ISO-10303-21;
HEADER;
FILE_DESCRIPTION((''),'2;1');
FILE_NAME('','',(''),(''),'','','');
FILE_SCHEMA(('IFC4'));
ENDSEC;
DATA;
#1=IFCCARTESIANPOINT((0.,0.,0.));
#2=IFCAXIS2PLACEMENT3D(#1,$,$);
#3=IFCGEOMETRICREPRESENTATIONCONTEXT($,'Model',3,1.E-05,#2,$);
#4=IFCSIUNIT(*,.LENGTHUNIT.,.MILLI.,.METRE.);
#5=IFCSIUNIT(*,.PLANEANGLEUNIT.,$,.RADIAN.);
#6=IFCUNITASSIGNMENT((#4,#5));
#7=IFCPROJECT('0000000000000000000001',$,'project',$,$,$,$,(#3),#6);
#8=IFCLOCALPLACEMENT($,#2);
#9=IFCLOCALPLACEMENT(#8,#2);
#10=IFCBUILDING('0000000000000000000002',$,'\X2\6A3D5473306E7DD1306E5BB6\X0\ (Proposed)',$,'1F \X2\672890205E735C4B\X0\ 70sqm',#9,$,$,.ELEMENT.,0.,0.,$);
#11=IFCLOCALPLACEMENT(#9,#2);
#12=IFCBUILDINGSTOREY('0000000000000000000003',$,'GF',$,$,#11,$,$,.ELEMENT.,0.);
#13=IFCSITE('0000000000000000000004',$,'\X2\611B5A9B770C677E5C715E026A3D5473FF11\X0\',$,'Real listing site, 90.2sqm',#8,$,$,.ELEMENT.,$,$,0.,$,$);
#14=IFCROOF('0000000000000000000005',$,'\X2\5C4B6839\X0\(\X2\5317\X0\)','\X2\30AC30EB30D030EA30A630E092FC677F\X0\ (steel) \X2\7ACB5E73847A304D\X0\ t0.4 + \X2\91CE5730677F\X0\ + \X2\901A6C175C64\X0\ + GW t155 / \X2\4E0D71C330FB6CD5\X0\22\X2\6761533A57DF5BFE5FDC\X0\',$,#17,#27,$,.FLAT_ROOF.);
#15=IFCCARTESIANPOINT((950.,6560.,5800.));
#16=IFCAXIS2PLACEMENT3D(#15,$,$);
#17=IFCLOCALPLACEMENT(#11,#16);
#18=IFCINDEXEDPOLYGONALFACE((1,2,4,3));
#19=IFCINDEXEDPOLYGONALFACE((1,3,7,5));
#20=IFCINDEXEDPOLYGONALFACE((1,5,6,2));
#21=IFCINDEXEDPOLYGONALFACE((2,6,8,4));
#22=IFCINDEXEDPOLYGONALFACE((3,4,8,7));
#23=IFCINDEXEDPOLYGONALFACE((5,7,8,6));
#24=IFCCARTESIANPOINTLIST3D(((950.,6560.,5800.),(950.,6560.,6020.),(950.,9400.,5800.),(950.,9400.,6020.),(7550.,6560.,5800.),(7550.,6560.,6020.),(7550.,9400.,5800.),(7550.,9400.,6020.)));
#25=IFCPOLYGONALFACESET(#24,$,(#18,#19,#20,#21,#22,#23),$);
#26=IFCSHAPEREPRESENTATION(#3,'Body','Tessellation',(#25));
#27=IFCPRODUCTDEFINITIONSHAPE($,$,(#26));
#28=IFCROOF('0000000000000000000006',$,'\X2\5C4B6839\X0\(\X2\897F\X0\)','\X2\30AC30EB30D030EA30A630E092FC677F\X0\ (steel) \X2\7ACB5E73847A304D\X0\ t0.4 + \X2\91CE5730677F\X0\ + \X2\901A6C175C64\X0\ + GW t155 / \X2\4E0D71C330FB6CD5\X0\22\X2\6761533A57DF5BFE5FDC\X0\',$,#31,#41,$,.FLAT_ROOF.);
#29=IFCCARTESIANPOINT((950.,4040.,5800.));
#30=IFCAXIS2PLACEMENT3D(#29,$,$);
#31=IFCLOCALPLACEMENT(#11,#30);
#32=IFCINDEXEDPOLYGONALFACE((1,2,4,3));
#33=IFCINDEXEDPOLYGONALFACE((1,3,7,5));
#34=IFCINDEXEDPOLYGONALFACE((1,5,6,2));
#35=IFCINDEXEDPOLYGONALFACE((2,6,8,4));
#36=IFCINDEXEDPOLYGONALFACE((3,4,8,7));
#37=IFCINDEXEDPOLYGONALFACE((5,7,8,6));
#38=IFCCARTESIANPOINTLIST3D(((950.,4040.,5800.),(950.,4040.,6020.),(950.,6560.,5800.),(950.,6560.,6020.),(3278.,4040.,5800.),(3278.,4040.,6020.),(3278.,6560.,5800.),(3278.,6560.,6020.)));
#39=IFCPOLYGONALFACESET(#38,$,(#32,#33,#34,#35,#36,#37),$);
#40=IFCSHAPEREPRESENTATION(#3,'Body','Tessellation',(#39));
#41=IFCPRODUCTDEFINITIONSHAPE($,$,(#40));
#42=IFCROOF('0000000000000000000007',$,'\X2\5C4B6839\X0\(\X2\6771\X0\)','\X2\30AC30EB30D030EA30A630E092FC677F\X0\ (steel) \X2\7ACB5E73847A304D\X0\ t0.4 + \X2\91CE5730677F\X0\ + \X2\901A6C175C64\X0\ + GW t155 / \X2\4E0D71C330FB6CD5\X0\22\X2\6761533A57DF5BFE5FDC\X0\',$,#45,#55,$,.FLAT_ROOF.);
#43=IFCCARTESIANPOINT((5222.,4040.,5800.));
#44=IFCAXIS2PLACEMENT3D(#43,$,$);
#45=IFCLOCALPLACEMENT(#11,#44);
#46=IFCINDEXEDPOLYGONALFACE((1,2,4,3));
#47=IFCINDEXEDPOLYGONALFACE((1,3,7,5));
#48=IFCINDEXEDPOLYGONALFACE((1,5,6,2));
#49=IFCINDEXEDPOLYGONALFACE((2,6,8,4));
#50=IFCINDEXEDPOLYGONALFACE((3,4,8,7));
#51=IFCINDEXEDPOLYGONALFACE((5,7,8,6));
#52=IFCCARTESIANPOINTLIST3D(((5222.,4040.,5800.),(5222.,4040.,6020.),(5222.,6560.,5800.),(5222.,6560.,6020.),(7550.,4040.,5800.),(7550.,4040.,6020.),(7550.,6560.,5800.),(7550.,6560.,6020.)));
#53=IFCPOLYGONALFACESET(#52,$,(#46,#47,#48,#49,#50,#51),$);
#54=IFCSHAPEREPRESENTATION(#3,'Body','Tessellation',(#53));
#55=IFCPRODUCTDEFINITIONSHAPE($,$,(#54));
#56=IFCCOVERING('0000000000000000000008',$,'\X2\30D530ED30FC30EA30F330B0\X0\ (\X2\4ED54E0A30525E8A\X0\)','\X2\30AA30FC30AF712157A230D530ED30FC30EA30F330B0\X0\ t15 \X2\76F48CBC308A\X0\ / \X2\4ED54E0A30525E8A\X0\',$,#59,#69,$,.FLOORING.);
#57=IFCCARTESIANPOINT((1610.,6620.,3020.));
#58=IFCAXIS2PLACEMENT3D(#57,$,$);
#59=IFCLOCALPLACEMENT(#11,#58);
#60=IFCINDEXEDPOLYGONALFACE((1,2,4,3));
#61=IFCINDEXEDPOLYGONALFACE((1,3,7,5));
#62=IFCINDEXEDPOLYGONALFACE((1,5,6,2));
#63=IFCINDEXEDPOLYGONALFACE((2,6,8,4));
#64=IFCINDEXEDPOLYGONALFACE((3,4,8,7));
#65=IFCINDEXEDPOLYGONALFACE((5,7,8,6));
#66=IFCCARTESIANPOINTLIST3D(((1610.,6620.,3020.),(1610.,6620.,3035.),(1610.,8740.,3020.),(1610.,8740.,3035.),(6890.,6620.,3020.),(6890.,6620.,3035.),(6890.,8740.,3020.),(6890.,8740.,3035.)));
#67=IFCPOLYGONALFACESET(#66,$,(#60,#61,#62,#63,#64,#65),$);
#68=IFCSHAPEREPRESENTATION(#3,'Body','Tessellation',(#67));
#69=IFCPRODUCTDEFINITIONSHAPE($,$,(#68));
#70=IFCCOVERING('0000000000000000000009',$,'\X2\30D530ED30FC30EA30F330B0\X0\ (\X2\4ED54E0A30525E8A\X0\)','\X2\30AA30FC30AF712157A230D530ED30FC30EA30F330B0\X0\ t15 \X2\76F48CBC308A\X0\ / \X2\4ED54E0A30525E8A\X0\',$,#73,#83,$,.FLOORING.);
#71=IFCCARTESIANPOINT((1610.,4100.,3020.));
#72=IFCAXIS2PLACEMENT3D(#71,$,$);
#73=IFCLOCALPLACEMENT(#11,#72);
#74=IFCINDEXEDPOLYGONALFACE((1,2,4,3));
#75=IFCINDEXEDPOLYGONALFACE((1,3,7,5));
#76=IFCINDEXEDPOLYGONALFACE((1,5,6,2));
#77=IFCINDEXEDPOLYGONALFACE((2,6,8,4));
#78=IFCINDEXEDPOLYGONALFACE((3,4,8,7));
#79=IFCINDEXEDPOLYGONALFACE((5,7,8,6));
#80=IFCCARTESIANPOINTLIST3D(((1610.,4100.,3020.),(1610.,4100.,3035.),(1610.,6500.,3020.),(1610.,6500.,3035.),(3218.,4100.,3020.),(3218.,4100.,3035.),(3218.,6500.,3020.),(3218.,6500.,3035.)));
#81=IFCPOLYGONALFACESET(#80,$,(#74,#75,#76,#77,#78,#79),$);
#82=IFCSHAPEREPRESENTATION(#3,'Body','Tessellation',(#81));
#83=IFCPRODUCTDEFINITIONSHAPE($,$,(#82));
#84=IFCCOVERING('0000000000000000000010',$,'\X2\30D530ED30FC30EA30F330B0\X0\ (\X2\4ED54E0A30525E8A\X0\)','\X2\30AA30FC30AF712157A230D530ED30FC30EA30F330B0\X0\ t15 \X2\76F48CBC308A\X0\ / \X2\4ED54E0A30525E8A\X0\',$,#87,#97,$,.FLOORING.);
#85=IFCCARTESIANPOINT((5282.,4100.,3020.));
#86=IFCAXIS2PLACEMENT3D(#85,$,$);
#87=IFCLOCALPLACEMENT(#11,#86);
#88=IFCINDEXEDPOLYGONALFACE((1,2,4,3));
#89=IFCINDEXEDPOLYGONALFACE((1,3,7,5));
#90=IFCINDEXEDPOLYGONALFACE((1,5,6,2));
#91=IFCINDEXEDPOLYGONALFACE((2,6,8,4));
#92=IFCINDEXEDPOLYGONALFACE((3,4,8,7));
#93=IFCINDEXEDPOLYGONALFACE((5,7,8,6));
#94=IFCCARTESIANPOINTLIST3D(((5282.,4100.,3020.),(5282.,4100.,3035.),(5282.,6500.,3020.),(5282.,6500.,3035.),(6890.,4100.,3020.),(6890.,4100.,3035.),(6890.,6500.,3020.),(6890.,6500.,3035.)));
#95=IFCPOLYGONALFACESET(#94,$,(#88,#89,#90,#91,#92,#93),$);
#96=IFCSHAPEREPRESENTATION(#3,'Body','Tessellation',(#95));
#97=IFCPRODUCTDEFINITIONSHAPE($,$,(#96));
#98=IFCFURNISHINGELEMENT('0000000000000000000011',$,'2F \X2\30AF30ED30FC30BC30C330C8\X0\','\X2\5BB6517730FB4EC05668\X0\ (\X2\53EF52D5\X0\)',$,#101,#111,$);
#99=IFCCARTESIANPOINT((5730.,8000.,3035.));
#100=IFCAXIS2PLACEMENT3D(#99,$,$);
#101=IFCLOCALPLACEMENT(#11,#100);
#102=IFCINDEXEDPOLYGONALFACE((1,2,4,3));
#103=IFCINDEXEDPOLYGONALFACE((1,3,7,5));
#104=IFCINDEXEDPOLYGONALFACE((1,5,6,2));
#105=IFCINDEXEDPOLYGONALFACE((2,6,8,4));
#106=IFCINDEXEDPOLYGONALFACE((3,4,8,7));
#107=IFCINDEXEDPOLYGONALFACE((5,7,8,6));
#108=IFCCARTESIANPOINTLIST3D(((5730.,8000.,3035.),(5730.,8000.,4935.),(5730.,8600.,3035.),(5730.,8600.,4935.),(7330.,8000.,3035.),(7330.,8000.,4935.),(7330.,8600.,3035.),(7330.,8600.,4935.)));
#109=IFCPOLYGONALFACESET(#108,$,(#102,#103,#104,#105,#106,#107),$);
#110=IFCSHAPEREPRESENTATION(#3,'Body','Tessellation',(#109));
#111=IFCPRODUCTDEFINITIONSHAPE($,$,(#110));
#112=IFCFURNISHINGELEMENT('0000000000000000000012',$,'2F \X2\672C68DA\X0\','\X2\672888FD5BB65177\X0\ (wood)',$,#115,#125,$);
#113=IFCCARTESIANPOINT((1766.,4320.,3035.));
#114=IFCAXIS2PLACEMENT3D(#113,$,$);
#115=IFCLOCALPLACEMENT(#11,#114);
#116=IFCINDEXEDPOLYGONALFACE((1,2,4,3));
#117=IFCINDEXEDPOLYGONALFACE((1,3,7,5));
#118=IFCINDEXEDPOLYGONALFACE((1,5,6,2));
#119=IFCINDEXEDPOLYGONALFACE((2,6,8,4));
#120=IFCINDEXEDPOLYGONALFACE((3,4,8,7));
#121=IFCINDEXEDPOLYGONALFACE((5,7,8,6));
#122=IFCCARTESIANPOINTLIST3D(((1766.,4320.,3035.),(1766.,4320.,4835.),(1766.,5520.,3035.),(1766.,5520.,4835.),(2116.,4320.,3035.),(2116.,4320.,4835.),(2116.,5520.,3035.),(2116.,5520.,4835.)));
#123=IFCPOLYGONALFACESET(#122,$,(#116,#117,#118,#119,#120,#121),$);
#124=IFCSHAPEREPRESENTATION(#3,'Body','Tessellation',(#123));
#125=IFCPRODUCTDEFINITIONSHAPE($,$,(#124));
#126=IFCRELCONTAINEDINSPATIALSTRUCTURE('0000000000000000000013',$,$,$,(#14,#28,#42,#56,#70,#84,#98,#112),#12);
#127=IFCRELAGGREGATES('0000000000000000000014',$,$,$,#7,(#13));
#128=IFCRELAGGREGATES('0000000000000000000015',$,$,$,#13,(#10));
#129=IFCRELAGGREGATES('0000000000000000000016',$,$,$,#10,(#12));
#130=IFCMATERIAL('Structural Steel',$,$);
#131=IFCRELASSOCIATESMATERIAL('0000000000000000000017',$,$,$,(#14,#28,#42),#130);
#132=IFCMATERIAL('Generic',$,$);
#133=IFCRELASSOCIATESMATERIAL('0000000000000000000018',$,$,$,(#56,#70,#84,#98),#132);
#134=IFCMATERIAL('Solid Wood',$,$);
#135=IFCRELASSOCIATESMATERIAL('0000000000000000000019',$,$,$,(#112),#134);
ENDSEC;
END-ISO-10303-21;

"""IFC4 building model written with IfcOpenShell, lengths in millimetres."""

from ifc_helpers import new_model, si_unit, frame, frame_2d, origin, place, context, project, spatial, rectangle, extrude, material, element, save


model = new_model("IFC4")

# Units and contexts
model_context = context("Model", 3, precision=1e-05, world=origin())
ifc_project = project(units=[si_unit("LENGTHUNIT", "METRE", prefix="MILLI"), si_unit("PLANEANGLEUNIT", "RADIAN")], contexts=[model_context])

# Site, building, storey
site_placement = place(None, origin())
site = spatial("IfcSite", under=ifc_project, at=site_placement, Name="愛媛県松山市樽味１", ObjectType="Real listing site, 90.2sqm", CompositionType="ELEMENT", RefElevation=0.0)
building_placement = place(site_placement, origin())
building = spatial("IfcBuilding", under=site, at=building_placement, Name="樽味の緑の家 (Proposed)", ObjectType="1F 木造平屋 70sqm", CompositionType="ELEMENT", ElevationOfRefHeight=0.0, ElevationOfTerrain=0.0)
storey_placement = place(building_placement, origin())
storey = spatial("IfcBuildingStorey", under=building, at=storey_placement, Name="GF", CompositionType="ELEMENT", Elevation=0.0)

# Shared definitions
ifc_material_1 = material(Name="Solid Wood")

# Shared definitions
ifc_material_2 = material(Name="Generic")

# Roofs
ifc_material_3 = material(Name="Structural Steel")
for number, where, name in (
    (1, (950.0, 6560.0, 5800.0), "屋根(北)"),
):
    element("IfcRoof", number, at=place(storey_placement, frame(where)), inside=storey, material=ifc_material_3, Name=name, Description="ガルバリウム鋼板 (steel) 立平葺き t0.4 + 野地板 + 通気層 + GW t155 / 不燃・法22条区域対応", PredefinedType="FLAT_ROOF", context=model_context, shape_type="SweptSolid", body=[
        extrude(rectangle(XDim=6600.0, YDim=2840.0, at=frame_2d((3300.0, 1420.0))), frame((950.0, 6560.0, 5800.0)), (0.0, 0.0, 1.0), 220.0),
    ])
roof_1_placement = place(storey_placement, frame((950.0, 4040.0, 5800.0)))
element("IfcRoof", 2, at=roof_1_placement, inside=storey, material=ifc_material_3, Name="屋根(西)", Description="ガルバリウム鋼板 (steel) 立平葺き t0.4 + 野地板 + 通気層 + GW t155 / 不燃・法22条区域対応", PredefinedType="FLAT_ROOF", context=model_context, shape_type="SweptSolid", body=[
    extrude(rectangle(XDim=2328.0, YDim=2520.0, at=frame_2d((1164.0, 1260.0))), frame((950.0, 4040.0, 5800.0)), (0.0, 0.0, 1.0), 220.0),
])
roof_2_placement = place(storey_placement, frame((5222.0, 4040.0, 5800.0)))
element("IfcRoof", 3, at=roof_2_placement, inside=storey, material=ifc_material_3, Name="屋根(東)", Description="ガルバリウム鋼板 (steel) 立平葺き t0.4 + 野地板 + 通気層 + GW t155 / 不燃・法22条区域対応", PredefinedType="FLAT_ROOF", context=model_context, shape_type="SweptSolid", body=[
    extrude(rectangle(XDim=2328.0, YDim=2520.0, at=frame_2d((1164.0, 1260.0))), frame((5222.0, 4040.0, 5800.0)), (0.0, 0.0, 1.0), 220.0),
])

# Coverings
covering_1_placement = place(storey_placement, frame((1610.0, 6620.0, 3020.0)))
element("IfcCovering", 4, at=covering_1_placement, inside=storey, material=ifc_material_2, Name="フローリング (仕上げ床)", Description="オーク無垢フローリング t15 直貼り / 仕上げ床", PredefinedType="FLOORING", context=model_context, shape_type="SweptSolid", body=[
    extrude(rectangle(XDim=5280.0, YDim=2120.0, at=frame_2d((2640.0, 1060.0))), frame((1610.0, 6620.0, 3020.0)), (0.0, 0.0, 1.0), 15.0),
])
covering_2_placement = place(storey_placement, frame((1610.0, 4100.0, 3020.0)))
element("IfcCovering", 5, at=covering_2_placement, inside=storey, material=ifc_material_2, Name="フローリング (仕上げ床)", Description="オーク無垢フローリング t15 直貼り / 仕上げ床", PredefinedType="FLOORING", context=model_context, shape_type="SweptSolid", body=[
    extrude(rectangle(XDim=1608.0, YDim=2400.0, at=frame_2d((804.0, 1200.0))), frame((1610.0, 4100.0, 3020.0)), (0.0, 0.0, 1.0), 15.0),
])
covering_3_placement = place(storey_placement, frame((5282.0, 4100.0, 3020.0)))
element("IfcCovering", 6, at=covering_3_placement, inside=storey, material=ifc_material_2, Name="フローリング (仕上げ床)", Description="オーク無垢フローリング t15 直貼り / 仕上げ床", PredefinedType="FLOORING", context=model_context, shape_type="SweptSolid", body=[
    extrude(rectangle(XDim=1608.0, YDim=2400.0, at=frame_2d((804.0, 1200.0))), frame((5282.0, 4100.0, 3020.0)), (0.0, 0.0, 1.0), 15.0),
])

# Furnishing elements
furnishing_1_placement = place(storey_placement, frame((5730.0, 8000.0, 3035.0)))
element("IfcFurnishingElement", 7, at=furnishing_1_placement, inside=storey, material=ifc_material_2, Name="2F クローゼット", Description="家具・什器 (可動)", context=model_context, shape_type="SweptSolid", body=[
    extrude(rectangle(XDim=1600.0, YDim=600.0, at=frame_2d((800.0, 300.0))), frame((5730.0, 8000.0, 3035.0)), (0.0, 0.0, 1.0), 1900.0),
])
furnishing_2_placement = place(storey_placement, frame((1766.0, 4320.0, 3035.0)))
element("IfcFurnishingElement", 8, at=furnishing_2_placement, inside=storey, material=ifc_material_1, Name="2F 本棚", Description="木製家具 (wood)", context=model_context, shape_type="SweptSolid", body=[
    extrude(rectangle(XDim=350.0, YDim=1200.0, at=frame_2d((175.0, 600.0))), frame((1766.0, 4320.0, 3035.0)), (0.0, 0.0, 1.0), 1800.0),
])

save(model, "model.ifc")
